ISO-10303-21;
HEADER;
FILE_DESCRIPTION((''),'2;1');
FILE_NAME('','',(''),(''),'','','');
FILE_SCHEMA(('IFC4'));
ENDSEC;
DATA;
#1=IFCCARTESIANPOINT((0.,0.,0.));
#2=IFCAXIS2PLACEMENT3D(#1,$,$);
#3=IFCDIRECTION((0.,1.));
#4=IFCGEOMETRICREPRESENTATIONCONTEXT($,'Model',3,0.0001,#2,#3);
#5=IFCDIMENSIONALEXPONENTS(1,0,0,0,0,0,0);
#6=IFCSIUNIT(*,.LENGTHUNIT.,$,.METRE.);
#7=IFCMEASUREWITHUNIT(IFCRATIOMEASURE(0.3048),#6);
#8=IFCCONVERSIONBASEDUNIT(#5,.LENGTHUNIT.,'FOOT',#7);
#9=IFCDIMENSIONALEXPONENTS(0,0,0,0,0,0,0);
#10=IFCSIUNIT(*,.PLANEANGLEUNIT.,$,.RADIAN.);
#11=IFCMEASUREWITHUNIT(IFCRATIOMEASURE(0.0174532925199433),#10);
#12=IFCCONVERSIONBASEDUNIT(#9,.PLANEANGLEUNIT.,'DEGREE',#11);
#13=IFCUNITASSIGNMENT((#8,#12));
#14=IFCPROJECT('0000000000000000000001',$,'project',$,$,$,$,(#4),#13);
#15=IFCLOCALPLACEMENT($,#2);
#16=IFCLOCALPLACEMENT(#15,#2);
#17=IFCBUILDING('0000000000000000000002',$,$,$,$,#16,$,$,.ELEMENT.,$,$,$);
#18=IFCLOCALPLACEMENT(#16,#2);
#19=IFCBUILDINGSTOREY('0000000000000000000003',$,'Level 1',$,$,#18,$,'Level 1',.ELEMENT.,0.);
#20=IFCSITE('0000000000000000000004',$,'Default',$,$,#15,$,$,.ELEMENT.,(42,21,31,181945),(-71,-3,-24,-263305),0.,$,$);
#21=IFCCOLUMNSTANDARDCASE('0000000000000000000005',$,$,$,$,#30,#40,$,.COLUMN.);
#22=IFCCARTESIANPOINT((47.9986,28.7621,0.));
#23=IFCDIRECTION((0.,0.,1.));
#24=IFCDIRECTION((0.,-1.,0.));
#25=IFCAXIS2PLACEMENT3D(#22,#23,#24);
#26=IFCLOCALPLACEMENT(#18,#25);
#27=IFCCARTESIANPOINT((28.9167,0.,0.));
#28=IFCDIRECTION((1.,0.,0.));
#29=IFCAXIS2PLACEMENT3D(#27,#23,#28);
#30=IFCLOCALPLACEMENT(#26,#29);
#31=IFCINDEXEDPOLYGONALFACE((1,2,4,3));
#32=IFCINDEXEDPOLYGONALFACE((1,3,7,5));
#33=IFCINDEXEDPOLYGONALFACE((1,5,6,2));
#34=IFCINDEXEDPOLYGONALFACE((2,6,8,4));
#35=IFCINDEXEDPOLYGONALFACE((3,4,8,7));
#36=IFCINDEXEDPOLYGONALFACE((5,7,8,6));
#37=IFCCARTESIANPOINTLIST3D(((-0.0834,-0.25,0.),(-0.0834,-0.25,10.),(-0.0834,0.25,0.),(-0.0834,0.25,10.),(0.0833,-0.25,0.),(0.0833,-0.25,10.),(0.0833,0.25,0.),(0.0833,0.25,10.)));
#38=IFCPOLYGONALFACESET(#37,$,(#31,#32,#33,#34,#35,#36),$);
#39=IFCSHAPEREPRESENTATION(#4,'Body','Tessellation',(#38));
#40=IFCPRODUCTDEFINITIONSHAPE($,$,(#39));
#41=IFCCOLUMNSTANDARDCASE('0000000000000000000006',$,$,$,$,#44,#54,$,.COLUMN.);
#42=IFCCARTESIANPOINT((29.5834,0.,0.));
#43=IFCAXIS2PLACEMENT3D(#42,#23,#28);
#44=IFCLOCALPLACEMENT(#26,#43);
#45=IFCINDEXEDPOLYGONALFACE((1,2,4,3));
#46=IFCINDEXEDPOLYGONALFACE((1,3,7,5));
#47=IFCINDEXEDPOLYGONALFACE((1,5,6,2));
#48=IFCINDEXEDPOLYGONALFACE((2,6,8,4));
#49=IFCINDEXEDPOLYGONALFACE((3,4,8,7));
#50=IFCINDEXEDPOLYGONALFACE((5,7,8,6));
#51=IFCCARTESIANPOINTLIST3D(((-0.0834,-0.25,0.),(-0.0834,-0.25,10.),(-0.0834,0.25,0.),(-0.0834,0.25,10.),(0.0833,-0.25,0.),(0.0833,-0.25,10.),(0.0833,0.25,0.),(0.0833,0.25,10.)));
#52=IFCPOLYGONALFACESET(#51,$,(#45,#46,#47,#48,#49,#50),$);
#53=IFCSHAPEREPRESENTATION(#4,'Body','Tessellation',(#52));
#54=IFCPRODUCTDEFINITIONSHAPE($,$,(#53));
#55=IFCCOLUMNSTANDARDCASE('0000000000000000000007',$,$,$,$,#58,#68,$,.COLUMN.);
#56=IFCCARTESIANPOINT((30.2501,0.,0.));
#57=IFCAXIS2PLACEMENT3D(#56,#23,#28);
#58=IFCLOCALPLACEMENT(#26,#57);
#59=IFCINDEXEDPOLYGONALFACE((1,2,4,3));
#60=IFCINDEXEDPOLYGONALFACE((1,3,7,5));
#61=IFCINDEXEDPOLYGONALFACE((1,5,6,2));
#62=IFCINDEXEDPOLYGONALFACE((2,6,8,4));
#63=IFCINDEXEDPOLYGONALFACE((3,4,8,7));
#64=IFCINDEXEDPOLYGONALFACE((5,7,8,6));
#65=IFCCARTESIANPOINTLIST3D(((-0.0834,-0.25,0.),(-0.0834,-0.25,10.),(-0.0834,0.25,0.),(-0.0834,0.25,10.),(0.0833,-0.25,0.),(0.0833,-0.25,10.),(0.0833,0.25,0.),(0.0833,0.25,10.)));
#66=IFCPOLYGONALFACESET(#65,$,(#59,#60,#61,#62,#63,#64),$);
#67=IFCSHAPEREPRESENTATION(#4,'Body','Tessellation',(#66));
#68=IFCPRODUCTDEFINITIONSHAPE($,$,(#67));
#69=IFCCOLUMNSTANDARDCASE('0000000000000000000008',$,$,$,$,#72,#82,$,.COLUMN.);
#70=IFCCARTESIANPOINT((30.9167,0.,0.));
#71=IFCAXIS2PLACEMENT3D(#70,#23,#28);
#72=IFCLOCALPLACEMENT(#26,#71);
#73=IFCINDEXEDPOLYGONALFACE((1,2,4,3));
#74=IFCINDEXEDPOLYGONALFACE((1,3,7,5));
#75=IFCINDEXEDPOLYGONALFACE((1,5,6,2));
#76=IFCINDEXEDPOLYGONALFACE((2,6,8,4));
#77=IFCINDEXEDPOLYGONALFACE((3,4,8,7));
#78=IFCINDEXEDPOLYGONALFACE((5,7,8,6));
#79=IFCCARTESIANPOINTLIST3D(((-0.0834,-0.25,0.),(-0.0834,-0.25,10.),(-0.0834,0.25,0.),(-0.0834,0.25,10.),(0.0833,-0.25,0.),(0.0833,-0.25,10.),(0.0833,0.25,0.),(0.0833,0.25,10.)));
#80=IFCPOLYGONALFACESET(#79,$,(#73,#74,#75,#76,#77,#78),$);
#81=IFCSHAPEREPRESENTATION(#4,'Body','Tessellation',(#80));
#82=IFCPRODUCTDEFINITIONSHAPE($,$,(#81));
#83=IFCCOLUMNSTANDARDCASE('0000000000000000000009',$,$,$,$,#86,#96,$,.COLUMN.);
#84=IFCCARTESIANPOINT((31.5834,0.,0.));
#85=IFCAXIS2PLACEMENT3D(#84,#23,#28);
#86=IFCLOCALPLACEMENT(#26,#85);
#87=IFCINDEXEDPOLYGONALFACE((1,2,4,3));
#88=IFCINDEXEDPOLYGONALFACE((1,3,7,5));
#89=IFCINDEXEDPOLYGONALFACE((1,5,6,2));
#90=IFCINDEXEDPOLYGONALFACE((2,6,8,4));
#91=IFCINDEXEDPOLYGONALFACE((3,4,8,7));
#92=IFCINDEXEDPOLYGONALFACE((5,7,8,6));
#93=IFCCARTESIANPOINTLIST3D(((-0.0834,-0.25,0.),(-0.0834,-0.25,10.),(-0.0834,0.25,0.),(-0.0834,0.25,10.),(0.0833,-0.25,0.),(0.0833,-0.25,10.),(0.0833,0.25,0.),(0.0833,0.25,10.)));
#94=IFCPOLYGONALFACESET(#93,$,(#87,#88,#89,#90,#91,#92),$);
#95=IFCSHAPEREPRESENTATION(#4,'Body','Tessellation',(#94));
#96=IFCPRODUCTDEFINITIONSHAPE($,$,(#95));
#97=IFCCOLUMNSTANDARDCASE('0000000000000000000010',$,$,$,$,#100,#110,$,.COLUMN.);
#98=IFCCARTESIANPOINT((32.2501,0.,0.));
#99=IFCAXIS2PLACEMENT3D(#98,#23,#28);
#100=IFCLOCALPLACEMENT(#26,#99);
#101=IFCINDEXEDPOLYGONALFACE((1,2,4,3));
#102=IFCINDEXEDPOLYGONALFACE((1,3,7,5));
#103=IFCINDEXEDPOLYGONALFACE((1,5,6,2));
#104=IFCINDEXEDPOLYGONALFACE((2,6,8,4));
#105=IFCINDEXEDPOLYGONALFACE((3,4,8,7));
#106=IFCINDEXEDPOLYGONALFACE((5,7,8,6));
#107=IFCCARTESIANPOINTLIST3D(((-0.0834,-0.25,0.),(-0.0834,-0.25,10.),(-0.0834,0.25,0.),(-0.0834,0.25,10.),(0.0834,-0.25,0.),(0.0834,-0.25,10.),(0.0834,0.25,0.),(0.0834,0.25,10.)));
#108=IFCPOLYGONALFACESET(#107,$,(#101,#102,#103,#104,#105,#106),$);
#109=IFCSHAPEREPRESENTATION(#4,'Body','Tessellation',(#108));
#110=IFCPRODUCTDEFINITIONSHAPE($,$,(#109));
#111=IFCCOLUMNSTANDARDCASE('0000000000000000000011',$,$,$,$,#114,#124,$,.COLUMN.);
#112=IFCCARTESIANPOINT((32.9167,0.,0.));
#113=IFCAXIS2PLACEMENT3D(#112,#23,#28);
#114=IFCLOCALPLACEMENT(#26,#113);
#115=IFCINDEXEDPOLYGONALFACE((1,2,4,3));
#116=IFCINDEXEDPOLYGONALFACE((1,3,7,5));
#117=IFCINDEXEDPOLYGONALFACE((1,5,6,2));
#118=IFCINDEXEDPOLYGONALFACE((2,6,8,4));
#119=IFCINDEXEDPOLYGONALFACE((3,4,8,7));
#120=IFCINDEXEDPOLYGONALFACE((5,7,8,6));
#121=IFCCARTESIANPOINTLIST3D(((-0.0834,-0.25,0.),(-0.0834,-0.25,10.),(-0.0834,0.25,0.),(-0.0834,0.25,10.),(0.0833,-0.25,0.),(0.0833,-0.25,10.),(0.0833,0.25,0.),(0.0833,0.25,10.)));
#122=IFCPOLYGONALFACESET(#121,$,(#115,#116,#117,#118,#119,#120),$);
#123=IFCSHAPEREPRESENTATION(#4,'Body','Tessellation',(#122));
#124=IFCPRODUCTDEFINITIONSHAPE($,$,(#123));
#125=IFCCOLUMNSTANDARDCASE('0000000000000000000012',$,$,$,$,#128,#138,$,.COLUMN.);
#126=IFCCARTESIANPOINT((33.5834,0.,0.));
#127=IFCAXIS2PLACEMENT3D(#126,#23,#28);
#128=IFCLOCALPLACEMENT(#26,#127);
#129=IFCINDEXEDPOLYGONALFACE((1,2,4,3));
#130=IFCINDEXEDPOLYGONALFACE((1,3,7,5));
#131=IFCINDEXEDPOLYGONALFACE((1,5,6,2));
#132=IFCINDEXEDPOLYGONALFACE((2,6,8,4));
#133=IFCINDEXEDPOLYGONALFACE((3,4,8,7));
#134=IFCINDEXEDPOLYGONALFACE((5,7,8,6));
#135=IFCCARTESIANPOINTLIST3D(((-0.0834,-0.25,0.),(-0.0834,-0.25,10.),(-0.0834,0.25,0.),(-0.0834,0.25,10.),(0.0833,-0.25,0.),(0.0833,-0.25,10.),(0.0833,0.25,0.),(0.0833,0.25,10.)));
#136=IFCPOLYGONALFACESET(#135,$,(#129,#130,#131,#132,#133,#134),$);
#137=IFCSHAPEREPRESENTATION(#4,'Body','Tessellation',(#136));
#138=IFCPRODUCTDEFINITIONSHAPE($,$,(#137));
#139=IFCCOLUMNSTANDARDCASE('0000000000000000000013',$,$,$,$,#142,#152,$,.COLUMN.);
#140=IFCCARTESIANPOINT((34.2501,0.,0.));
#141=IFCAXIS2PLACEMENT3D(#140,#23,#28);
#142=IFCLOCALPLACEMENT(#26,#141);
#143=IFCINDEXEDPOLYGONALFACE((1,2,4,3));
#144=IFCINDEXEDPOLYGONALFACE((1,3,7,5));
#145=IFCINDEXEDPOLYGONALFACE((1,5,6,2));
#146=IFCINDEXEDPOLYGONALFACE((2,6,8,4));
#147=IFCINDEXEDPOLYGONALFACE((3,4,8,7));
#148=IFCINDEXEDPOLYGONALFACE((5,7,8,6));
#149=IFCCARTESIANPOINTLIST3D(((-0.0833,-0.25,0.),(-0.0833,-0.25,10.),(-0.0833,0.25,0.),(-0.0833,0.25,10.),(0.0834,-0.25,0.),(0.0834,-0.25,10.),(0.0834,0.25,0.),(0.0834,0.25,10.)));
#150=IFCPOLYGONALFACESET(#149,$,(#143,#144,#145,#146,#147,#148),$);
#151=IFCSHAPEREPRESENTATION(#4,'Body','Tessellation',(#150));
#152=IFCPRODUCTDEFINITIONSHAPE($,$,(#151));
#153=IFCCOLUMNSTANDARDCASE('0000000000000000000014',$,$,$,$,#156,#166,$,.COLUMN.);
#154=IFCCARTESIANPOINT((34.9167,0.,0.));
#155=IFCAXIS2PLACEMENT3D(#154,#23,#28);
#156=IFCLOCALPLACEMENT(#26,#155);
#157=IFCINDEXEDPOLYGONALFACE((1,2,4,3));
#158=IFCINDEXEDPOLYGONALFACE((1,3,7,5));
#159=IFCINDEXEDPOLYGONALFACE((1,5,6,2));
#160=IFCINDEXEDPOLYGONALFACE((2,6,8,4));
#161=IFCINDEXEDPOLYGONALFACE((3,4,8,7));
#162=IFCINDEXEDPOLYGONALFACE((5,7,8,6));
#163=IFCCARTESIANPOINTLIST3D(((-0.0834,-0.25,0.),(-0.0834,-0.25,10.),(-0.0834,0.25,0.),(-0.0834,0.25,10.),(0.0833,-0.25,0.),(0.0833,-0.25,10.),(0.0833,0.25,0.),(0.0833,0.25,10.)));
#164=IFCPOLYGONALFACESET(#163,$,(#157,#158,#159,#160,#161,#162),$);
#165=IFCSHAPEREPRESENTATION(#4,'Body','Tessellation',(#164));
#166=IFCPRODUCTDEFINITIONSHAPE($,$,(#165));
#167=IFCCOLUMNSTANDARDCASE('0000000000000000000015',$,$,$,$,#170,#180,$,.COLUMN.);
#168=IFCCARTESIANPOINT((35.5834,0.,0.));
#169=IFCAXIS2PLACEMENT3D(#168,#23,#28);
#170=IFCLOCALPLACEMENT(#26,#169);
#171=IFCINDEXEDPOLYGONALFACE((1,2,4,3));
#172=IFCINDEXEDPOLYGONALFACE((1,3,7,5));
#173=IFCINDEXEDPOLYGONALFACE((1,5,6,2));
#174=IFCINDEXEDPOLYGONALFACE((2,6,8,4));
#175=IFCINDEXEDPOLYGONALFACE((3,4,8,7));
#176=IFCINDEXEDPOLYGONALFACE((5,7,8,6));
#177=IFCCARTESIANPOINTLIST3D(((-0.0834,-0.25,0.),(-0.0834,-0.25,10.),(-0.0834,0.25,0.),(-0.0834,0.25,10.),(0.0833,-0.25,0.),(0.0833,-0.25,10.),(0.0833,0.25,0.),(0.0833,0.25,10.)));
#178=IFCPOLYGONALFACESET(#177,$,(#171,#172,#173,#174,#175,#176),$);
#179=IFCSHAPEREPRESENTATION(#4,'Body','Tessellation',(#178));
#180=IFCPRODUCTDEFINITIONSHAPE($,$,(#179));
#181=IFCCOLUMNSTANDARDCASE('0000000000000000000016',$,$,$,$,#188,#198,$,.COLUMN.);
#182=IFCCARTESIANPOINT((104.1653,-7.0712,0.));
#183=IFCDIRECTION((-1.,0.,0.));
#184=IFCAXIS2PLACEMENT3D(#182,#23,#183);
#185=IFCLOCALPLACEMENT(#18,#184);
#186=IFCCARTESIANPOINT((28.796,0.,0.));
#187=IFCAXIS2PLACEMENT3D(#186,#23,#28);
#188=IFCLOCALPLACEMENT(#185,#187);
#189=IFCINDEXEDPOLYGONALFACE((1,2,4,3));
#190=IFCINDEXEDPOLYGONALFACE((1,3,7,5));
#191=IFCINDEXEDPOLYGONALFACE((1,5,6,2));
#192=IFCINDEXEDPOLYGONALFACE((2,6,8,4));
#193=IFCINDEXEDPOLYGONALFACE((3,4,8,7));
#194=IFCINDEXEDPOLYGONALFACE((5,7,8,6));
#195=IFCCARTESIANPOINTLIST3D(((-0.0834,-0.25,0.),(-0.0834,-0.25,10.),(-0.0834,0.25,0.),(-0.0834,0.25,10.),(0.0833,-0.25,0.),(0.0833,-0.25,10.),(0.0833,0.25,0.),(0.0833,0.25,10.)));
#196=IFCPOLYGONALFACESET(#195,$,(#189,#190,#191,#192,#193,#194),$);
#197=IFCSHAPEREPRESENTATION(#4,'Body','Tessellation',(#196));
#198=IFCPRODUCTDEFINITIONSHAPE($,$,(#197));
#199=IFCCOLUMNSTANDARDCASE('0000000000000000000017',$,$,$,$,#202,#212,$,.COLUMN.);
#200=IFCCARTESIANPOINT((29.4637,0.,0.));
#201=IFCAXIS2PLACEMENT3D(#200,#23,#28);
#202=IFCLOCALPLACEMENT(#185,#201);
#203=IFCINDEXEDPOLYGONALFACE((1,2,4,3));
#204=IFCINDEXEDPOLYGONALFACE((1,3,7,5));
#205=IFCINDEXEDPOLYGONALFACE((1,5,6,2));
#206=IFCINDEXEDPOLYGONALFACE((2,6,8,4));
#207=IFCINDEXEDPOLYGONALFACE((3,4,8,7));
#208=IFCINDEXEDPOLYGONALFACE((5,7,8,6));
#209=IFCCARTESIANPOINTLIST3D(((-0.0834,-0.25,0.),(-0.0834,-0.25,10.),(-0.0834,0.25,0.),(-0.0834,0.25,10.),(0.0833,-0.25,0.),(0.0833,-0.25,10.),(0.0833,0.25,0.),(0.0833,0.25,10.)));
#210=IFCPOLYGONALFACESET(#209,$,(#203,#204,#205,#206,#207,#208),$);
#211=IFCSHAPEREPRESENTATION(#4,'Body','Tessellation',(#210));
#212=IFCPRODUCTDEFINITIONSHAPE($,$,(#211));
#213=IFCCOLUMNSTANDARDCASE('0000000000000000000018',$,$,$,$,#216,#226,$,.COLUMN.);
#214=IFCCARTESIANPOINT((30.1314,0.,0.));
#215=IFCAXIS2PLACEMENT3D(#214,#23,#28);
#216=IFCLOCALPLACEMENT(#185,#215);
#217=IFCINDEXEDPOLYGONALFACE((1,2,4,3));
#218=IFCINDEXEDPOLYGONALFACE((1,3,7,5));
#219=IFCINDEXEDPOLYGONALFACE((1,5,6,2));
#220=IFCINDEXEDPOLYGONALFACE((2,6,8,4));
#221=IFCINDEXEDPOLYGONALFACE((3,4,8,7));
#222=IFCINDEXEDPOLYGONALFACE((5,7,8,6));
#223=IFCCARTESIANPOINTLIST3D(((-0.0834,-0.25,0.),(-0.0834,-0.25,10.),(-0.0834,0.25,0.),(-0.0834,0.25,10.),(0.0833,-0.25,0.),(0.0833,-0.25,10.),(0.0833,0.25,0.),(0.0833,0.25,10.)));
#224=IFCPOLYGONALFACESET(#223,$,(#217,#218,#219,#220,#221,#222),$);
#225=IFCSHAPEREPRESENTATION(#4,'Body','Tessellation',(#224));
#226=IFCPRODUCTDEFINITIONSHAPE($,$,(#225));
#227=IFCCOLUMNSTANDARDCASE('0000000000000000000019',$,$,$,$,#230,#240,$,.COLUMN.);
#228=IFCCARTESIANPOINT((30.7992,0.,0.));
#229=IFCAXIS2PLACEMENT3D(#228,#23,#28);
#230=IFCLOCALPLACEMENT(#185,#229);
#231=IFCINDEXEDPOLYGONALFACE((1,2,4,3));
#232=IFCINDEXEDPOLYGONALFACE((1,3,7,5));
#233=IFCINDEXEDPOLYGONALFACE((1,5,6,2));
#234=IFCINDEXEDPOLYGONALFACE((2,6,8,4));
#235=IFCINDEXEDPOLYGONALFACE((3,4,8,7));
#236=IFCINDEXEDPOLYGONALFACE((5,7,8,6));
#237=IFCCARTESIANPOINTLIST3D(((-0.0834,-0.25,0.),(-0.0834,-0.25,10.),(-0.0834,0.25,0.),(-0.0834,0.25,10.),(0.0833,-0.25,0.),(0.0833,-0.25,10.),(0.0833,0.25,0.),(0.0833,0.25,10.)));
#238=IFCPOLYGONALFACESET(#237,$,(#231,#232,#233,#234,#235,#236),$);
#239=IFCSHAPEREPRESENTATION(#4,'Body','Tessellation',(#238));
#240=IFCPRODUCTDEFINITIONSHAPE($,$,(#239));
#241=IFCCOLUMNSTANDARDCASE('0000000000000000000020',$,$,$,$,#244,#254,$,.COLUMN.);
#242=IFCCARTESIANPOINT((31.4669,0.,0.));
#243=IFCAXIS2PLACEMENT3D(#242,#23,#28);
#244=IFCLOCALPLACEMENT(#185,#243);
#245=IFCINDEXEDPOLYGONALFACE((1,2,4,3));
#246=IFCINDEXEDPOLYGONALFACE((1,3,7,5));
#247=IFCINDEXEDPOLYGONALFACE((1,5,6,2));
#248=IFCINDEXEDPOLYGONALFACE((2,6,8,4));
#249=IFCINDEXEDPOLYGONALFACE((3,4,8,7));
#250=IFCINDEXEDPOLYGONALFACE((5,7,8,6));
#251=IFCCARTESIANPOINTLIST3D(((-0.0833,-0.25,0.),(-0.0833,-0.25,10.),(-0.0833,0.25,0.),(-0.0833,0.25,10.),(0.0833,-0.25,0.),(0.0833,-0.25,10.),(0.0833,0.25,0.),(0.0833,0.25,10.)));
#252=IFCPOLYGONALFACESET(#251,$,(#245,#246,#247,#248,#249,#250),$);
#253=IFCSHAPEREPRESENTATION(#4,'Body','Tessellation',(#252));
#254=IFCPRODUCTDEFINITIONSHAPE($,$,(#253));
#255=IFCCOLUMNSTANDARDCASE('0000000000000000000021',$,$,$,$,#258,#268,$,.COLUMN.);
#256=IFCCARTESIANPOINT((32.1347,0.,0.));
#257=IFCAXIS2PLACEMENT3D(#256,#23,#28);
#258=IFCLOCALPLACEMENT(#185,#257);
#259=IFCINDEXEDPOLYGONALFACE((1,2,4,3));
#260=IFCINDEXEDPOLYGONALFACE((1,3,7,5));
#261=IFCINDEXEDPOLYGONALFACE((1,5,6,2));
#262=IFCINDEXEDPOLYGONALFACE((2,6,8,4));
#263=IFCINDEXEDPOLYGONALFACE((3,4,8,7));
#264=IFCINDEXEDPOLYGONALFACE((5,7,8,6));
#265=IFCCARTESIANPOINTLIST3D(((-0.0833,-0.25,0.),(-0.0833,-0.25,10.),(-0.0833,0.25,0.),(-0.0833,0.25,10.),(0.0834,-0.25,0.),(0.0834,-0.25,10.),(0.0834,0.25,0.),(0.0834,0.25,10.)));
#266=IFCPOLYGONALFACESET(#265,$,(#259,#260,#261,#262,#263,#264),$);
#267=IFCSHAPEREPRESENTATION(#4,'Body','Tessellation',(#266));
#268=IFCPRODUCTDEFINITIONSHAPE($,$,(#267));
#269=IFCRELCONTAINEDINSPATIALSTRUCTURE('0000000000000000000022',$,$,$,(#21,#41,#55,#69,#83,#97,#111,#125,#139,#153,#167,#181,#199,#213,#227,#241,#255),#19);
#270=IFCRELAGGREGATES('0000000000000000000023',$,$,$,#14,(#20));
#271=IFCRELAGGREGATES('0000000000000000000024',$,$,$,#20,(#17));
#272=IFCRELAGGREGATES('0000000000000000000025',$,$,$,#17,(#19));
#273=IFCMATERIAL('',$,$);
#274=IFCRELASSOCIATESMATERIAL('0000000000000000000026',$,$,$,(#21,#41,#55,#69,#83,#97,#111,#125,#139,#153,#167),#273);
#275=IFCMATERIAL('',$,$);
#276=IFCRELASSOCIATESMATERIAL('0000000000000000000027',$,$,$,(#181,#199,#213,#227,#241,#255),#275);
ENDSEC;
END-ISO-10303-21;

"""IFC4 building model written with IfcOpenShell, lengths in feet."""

from ifc_helpers import new_model, entity, si_unit, converted_unit, direction, frame, origin, place, context, project, spatial, rectangle, extrude, material, element, save


model = new_model("IFC4")

# Units and contexts
model_context = context("Model", 3, precision=0.0001, world=origin(), true_north=direction((0.0, 1.0)))
ifc_project = project(units=[converted_unit("LENGTHUNIT", "FOOT", entity("IfcRatioMeasure", 0.3048), si_unit("LENGTHUNIT", "METRE"), dimensions=[1, 0, 0, 0, 0, 0, 0]), converted_unit("PLANEANGLEUNIT", "DEGREE", entity("IfcRatioMeasure", 0.0174532925199433), si_unit("PLANEANGLEUNIT", "RADIAN"), dimensions=[0, 0, 0, 0, 0, 0, 0])], contexts=[model_context])

# Site, building, storey
site_placement = place(None, origin())
site = spatial("IfcSite", under=ifc_project, at=site_placement, Name="Default", CompositionType="ELEMENT", RefLatitude=(42, 21, 31, 181945), RefLongitude=(-71, -3, -24, -263305), RefElevation=0.0)
building_placement = place(site_placement, origin())
building = spatial("IfcBuilding", under=site, at=building_placement, CompositionType="ELEMENT")
storey_placement = place(building_placement, origin())
storey = spatial("IfcBuildingStorey", under=building, at=storey_placement, Name="Level 1", LongName="Level 1", CompositionType="ELEMENT", Elevation=0.0)

# Columns
ifc_material_1 = material(Name="")
placement_1 = place(storey_placement, frame((47.9986, 28.7621, 0.0), z_axis=(0.0, 0.0, 1.0), x_axis=(0.0, -1.0, 0.0)))
for number, where, z_axis, x_axis in (
    (1, (28.9167, 0.0, 0.0), (0.0, 0.0, 1.0), (1.0, 0.0, 0.0)),
    (2, (29.5834, 0.0, 0.0), (0.0, 0.0, 1.0), (1.0, 0.0, 0.0)),
    (3, (30.2501, 0.0, 0.0), (0.0, 0.0, 1.0), (1.0, 0.0, 0.0)),
    (4, (30.9167, 0.0, 0.0), (0.0, 0.0, 1.0), (1.0, 0.0, 0.0)),
    (5, (31.5834, 0.0, 0.0), (0.0, 0.0, 1.0), (1.0, 0.0, 0.0)),
    (6, (32.2501, 0.0, 0.0), (0.0, 0.0, 1.0), (1.0, 0.0, 0.0)),
    (7, (32.9167, 0.0, 0.0), (0.0, 0.0, 1.0), (1.0, 0.0, 0.0)),
    (8, (33.5834, 0.0, 0.0), (0.0, 0.0, 1.0), (1.0, 0.0, 0.0)),
    (9, (34.2501, 0.0, 0.0), (0.0, 0.0, 1.0), (1.0, 0.0, 0.0)),
    (10, (34.9167, 0.0, 0.0), (0.0, 0.0, 1.0), (1.0, 0.0, 0.0)),
    (11, (35.5834, 0.0, 0.0), (0.0, 0.0, 1.0), (1.0, 0.0, 0.0)),
):
    element("IfcColumnStandardCase", number, at=place(placement_1, frame(where, z_axis=z_axis, x_axis=x_axis)), inside=storey, material=ifc_material_1, PredefinedType="COLUMN", context=model_context, shape_type="SweptSolid", body=[
        extrude(rectangle(XDim=0.1667, YDim=0.5), origin(), (0.0, 0.0, 1.0), 10.0),
    ])
ifc_material_2 = material(Name="")
placement_2 = place(storey_placement, frame((104.1653, -7.0712, 0.0), z_axis=(0.0, 0.0, 1.0), x_axis=(-1.0, 0.0, 0.0)))
for number, where, z_axis, x_axis in (
    (12, (28.796, 0.0, 0.0), (0.0, 0.0, 1.0), (1.0, 0.0, 0.0)),
    (13, (29.4637, 0.0, 0.0), (0.0, 0.0, 1.0), (1.0, 0.0, 0.0)),
    (14, (30.1314, 0.0, 0.0), (0.0, 0.0, 1.0), (1.0, 0.0, 0.0)),
    (15, (30.7992, 0.0, 0.0), (0.0, 0.0, 1.0), (1.0, 0.0, 0.0)),
    (16, (31.4669, 0.0, 0.0), (0.0, 0.0, 1.0), (1.0, 0.0, 0.0)),
    (17, (32.1347, 0.0, 0.0), (0.0, 0.0, 1.0), (1.0, 0.0, 0.0)),
):
    element("IfcColumnStandardCase", number, at=place(placement_2, frame(where, z_axis=z_axis, x_axis=x_axis)), inside=storey, material=ifc_material_2, PredefinedType="COLUMN", context=model_context, shape_type="SweptSolid", body=[
        extrude(rectangle(XDim=0.1667, YDim=0.5), origin(), (0.0, 0.0, 1.0), 10.0),
    ])

save(model, "model.ifc")
